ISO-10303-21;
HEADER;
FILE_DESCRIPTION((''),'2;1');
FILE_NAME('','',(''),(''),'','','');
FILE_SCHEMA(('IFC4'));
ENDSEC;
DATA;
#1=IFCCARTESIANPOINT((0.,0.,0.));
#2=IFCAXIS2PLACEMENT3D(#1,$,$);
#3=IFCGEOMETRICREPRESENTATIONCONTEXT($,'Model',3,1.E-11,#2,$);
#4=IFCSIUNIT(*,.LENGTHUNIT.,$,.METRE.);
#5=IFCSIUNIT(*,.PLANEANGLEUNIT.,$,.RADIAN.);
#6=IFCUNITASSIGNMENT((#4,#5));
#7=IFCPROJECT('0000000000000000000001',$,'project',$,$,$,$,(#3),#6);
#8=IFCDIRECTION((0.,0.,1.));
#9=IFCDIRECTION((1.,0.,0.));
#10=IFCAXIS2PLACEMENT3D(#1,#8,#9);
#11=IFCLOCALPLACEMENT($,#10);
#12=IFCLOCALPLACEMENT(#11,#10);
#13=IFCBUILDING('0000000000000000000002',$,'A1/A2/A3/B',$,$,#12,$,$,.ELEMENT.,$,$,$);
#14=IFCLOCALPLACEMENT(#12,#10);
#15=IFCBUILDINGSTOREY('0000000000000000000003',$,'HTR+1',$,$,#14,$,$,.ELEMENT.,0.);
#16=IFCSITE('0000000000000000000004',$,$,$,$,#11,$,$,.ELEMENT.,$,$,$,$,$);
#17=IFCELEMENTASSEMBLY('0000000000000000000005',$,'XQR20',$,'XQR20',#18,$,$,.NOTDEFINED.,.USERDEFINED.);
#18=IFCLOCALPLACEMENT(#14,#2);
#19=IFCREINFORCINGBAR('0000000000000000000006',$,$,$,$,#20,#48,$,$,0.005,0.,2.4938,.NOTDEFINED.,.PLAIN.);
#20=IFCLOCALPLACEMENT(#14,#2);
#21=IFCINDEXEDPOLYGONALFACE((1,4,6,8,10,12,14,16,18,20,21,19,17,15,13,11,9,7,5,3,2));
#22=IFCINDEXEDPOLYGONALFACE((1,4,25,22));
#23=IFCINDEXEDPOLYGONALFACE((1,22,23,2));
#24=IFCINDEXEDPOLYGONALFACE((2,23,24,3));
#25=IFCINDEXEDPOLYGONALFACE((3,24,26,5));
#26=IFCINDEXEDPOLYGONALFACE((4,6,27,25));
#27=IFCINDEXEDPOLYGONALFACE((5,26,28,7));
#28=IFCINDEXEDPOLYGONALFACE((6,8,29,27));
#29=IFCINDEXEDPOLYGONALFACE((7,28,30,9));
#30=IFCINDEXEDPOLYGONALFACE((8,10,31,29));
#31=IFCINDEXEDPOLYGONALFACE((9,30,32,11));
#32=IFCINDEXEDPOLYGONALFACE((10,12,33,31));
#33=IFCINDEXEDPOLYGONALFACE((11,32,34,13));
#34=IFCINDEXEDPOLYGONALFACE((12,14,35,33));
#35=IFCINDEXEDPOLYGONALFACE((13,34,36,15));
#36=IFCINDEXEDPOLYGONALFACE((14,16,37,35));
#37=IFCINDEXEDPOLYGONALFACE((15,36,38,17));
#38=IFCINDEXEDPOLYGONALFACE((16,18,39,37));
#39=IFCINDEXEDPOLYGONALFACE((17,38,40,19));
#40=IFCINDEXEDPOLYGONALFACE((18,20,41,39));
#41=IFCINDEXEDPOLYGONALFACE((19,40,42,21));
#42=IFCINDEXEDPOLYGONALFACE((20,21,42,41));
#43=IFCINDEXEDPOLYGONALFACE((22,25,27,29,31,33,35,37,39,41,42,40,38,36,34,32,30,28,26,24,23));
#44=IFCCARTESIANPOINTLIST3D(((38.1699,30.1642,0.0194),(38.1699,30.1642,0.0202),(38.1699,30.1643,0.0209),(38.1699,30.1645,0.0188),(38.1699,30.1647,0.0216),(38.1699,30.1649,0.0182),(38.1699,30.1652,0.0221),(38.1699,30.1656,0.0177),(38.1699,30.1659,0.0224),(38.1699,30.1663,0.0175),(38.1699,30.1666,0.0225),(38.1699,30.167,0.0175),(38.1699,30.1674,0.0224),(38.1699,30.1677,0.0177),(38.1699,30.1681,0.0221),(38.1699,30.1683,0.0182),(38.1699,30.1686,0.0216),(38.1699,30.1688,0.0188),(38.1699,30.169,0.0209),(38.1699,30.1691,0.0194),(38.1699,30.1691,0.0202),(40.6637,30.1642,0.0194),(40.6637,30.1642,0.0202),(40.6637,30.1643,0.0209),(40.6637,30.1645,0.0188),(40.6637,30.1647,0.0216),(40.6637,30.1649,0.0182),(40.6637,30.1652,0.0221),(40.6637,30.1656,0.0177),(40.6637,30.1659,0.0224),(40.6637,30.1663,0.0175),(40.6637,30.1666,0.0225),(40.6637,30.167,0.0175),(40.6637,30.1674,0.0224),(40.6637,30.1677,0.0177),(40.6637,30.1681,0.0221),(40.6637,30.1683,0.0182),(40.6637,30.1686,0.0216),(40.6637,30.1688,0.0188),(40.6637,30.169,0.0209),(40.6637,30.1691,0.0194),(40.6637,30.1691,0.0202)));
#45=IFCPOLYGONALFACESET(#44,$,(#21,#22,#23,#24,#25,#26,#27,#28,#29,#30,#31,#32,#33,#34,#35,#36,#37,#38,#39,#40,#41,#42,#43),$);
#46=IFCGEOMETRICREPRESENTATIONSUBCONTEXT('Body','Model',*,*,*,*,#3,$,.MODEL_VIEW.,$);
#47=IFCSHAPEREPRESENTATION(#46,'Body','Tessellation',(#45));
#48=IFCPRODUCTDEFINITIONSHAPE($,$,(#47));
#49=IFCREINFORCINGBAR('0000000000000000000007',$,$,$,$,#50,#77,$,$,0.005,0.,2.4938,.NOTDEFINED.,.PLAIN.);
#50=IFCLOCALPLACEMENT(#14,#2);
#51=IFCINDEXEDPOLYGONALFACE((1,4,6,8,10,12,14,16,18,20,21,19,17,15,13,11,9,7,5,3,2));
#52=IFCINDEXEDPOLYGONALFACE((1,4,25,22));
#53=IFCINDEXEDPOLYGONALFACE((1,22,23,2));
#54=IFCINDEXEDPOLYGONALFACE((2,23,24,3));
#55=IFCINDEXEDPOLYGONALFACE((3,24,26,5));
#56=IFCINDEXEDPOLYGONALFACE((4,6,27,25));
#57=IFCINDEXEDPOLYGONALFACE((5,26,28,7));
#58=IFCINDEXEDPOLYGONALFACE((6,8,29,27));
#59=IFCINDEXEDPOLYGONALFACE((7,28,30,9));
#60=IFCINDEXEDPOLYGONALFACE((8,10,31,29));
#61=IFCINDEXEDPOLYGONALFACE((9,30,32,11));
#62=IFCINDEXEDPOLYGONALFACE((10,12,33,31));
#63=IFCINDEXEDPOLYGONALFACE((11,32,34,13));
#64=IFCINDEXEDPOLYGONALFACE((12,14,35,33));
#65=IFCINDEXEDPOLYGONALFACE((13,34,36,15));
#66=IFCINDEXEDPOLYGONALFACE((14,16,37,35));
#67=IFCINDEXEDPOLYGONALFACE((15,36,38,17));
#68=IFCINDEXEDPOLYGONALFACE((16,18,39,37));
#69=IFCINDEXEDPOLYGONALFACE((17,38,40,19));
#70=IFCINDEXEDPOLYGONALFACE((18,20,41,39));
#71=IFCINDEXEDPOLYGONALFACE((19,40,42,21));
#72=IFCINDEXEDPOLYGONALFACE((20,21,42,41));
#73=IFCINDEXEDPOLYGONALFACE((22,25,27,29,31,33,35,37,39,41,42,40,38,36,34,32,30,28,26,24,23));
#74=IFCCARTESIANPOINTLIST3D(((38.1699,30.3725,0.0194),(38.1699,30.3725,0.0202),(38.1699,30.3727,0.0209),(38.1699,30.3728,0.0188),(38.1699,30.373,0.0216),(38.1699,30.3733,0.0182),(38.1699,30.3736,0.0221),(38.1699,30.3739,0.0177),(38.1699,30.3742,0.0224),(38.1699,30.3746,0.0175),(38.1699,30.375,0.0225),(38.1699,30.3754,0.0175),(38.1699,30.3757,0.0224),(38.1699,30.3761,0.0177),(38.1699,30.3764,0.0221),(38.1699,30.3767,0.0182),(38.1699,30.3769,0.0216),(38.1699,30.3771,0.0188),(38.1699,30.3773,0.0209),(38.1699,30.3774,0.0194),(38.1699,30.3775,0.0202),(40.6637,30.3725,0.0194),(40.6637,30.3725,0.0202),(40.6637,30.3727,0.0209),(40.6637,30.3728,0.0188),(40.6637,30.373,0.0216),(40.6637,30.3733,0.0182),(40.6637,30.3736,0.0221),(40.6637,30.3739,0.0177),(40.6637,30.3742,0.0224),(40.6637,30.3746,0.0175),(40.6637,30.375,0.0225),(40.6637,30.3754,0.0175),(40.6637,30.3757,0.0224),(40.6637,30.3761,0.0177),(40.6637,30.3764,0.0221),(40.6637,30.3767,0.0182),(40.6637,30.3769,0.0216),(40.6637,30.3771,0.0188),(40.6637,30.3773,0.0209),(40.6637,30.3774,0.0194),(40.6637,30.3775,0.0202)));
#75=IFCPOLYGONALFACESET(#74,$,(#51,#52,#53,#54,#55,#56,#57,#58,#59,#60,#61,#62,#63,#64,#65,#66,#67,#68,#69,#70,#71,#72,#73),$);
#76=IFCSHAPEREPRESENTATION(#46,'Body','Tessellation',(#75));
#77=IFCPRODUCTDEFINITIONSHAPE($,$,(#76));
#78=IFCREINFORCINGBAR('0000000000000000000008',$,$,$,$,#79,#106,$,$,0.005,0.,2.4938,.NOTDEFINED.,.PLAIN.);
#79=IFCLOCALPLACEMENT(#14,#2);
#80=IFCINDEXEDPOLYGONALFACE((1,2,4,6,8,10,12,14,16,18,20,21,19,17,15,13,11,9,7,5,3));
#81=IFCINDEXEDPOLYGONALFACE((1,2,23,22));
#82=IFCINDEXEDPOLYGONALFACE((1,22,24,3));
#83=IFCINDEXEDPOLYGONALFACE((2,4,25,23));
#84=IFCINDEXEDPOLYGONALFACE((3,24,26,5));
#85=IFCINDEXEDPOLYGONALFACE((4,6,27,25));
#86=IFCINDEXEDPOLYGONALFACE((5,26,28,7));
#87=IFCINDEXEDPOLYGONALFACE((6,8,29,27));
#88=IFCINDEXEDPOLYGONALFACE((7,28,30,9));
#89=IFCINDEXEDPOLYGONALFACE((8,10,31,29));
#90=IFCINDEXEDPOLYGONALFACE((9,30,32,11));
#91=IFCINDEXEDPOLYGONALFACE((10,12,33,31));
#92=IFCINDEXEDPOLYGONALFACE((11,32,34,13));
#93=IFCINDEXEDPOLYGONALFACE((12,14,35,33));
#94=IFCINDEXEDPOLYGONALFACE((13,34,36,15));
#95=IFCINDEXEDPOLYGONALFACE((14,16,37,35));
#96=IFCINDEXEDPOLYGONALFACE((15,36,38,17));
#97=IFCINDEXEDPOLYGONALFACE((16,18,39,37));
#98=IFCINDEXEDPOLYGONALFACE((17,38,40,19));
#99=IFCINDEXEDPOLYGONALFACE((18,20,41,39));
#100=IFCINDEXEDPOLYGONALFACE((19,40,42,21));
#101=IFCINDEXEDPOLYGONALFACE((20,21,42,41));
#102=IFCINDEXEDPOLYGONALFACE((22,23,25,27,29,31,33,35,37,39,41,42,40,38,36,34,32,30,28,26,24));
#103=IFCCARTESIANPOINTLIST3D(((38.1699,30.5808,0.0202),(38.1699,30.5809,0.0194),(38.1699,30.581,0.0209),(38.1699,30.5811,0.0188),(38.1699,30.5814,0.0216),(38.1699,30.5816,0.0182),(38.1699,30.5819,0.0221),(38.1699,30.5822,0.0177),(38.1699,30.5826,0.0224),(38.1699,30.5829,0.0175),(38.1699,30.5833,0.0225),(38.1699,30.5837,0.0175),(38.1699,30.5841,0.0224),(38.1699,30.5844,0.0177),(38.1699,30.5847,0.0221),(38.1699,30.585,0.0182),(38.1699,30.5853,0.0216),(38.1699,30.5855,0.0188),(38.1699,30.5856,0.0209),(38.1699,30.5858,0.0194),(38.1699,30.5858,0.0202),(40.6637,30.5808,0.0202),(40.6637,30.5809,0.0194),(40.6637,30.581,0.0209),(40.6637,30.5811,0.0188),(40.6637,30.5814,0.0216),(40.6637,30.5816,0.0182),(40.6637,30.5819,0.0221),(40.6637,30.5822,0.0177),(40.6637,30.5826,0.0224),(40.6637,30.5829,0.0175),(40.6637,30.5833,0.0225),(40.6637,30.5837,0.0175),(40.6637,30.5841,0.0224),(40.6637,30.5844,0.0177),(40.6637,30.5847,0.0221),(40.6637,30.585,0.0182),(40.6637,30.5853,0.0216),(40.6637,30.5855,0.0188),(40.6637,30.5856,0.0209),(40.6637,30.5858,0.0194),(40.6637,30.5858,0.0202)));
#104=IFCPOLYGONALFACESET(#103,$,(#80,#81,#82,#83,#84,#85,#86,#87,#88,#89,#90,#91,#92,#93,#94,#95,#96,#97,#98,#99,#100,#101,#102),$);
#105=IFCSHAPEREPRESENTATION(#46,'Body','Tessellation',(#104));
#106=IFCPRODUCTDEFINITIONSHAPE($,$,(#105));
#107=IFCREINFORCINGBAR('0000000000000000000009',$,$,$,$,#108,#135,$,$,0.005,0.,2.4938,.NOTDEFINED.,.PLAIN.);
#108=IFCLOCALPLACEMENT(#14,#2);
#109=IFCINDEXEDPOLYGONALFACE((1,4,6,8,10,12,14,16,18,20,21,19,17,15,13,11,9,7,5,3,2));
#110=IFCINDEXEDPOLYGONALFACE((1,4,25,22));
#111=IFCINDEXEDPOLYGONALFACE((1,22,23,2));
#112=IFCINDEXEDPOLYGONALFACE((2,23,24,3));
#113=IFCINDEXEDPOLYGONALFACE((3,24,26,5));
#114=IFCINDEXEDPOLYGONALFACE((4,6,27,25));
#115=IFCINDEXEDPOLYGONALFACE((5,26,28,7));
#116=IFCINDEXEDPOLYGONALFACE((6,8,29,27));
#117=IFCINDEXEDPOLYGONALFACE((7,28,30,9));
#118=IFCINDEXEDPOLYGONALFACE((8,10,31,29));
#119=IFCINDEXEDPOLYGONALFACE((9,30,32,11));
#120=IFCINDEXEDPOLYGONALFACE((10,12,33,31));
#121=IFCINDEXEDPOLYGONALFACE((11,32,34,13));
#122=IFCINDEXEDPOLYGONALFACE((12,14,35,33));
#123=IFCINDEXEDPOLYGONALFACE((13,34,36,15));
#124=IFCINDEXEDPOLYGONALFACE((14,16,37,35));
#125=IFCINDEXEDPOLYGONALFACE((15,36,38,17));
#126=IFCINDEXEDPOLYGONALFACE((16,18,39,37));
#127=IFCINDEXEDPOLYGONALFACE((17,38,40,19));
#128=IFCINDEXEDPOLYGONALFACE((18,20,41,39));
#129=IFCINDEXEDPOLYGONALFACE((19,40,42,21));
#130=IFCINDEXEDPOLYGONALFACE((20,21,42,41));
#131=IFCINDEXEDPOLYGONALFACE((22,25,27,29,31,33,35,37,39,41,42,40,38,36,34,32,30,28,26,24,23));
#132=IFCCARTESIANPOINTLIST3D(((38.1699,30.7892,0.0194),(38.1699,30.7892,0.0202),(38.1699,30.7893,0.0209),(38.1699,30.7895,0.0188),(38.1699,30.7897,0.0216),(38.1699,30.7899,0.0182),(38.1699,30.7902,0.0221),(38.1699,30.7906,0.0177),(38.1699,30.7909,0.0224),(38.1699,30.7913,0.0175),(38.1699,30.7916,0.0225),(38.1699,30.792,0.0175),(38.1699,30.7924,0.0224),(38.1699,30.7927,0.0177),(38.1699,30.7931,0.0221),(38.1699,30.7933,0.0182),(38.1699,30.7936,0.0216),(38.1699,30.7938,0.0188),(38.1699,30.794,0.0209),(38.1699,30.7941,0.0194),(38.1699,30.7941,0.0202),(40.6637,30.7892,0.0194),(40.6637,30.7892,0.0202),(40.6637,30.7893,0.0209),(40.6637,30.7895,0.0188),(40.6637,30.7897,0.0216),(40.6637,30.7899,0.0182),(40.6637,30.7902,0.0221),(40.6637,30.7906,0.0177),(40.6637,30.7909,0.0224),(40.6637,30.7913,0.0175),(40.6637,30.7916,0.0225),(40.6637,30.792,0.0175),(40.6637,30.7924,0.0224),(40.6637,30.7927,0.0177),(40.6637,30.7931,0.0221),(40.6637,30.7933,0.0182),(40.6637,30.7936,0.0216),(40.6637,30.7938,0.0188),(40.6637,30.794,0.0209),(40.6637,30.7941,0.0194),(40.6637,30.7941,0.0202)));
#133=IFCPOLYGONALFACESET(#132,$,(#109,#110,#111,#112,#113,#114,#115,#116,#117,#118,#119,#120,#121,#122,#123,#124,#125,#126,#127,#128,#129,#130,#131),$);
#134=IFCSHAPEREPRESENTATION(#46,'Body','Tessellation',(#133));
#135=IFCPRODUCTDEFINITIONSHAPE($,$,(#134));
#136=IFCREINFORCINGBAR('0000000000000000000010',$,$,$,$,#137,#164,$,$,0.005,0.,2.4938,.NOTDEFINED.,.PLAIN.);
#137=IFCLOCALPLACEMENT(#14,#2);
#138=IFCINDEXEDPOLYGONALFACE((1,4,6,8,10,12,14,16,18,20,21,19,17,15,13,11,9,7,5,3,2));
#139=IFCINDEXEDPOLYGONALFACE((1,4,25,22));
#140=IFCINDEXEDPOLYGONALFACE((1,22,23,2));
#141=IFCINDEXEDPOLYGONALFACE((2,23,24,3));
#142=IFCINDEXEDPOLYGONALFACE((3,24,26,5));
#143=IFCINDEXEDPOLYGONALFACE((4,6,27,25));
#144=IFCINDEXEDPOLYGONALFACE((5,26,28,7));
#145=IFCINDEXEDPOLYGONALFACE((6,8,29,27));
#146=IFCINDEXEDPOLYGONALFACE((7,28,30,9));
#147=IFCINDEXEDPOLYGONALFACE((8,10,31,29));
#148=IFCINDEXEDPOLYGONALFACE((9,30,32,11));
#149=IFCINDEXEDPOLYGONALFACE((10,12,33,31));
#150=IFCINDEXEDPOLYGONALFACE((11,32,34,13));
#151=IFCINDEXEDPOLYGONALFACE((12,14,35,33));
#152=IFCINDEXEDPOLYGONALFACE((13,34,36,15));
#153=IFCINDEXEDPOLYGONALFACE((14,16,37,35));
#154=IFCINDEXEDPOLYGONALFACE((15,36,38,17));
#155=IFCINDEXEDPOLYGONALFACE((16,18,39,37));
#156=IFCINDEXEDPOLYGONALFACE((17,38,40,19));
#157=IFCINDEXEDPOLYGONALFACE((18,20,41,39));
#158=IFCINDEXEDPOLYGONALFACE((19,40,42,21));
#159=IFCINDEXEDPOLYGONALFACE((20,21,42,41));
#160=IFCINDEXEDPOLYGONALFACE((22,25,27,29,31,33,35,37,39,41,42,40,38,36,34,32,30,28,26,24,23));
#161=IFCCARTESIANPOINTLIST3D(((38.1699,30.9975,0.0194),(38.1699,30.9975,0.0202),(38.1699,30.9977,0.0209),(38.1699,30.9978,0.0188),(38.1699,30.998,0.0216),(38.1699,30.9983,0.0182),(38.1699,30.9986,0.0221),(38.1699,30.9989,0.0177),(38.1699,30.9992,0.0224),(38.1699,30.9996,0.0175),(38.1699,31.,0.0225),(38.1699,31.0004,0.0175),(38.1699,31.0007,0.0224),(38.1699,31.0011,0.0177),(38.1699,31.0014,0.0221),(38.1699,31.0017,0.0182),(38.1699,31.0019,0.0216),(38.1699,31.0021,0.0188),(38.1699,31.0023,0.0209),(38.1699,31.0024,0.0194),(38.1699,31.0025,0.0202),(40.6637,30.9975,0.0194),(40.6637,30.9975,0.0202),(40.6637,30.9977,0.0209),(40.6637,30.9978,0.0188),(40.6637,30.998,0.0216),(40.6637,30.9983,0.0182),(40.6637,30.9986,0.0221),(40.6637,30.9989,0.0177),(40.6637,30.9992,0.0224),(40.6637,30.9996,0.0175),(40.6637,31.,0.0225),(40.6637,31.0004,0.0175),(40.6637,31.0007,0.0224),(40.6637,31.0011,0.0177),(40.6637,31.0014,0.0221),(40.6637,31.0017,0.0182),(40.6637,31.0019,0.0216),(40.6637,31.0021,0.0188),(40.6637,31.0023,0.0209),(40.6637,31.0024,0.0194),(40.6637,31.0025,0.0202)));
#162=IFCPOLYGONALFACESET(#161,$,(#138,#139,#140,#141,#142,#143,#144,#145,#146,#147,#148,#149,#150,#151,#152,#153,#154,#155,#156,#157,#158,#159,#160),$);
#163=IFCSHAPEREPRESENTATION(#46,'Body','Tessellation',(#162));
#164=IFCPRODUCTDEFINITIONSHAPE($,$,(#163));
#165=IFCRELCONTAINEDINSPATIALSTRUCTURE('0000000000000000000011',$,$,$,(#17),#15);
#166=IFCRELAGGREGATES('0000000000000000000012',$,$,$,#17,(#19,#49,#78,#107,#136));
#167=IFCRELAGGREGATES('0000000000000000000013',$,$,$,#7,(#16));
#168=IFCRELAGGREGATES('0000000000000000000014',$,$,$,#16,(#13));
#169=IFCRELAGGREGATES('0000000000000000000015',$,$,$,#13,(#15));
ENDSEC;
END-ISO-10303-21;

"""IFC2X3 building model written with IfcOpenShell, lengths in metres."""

from ifc_helpers import new_model, entity, si_unit, origin, origin_with_axes, place, context, subcontext, project, spatial, shape, element, aggregate, save


model = new_model("IFC2X3")

# Units and contexts
model_context = context("Model", 3, precision=1e-11, world=origin())
body_context = subcontext(model_context, "Body", "Model", "MODEL_VIEW")
ifc_project = project(units=[si_unit("LENGTHUNIT", "METRE"), si_unit("PLANEANGLEUNIT", "RADIAN")], contexts=[model_context])

# Site, building, storey
site_placement = place(None, origin_with_axes())
site = spatial("IfcSite", under=ifc_project, at=site_placement, CompositionType="ELEMENT")
building_placement = place(site_placement, origin_with_axes())
building = spatial("IfcBuilding", under=site, at=building_placement, Name="A1/A2/A3/B", CompositionType="ELEMENT")
storey_placement = place(building_placement, origin_with_axes())
storey = spatial("IfcBuildingStorey", under=building, at=storey_placement, Name="HTR+1", CompositionType="ELEMENT", Elevation=0.0)

# Element assembly, reinforcing bars
assembly_1_placement = place(storey_placement, origin_with_axes())
assembly_1 = element("IfcElementAssembly", 1, at=assembly_1_placement, inside=storey, Name="XQR20", ObjectType="XQR20", AssemblyPlace="NOTDEFINED", PredefinedType="USERDEFINED")
reinforcing_bar_1_placement = place(assembly_1_placement, origin_with_axes())
reinforcing_bar_1 = element("IfcReinforcingBar", 2, at=reinforcing_bar_1_placement, BarLength=2.4938, BarRole="NOTDEFINED", BarSurface="PLAIN", CrossSectionArea=0.0, NominalDiameter=0.005, shapes=[
    shape(body_context, "Body", "AdvancedSweptSolid", [entity("IfcSweptDiskSolid", entity("IfcPolyline", [entity("IfcCartesianPoint", [38.1699, 30.1666, 0.02]), entity("IfcCartesianPoint", [40.6637, 30.1666, 0.02])]), 0.0025, None, 0.0, 2.4938)]),
    shape(body_context, "Body", "AdvancedSweptSolid", [entity("IfcSweptDiskSolid", entity("IfcPolyline", [entity("IfcCartesianPoint", [38.1699, 30.1666, 0.02]), entity("IfcCartesianPoint", [40.6637, 30.1666, 0.02])]), 0.0025, None, 0.0, 2.4938)]),
])
reinforcing_bar_2_placement = place(assembly_1_placement, origin_with_axes())
reinforcing_bar_2 = element("IfcReinforcingBar", 3, at=reinforcing_bar_2_placement, BarLength=2.4938, BarRole="NOTDEFINED", BarSurface="PLAIN", CrossSectionArea=0.0, NominalDiameter=0.005, shapes=[
    shape(body_context, "Body", "AdvancedSweptSolid", [entity("IfcSweptDiskSolid", entity("IfcPolyline", [entity("IfcCartesianPoint", [38.1699, 30.375, 0.02]), entity("IfcCartesianPoint", [40.6637, 30.375, 0.02])]), 0.0025, None, 0.0, 2.4938)]),
    shape(body_context, "Body", "AdvancedSweptSolid", [entity("IfcSweptDiskSolid", entity("IfcPolyline", [entity("IfcCartesianPoint", [38.1699, 30.375, 0.02]), entity("IfcCartesianPoint", [40.6637, 30.375, 0.02])]), 0.0025, None, 0.0, 2.4938)]),
])
reinforcing_bar_3_placement = place(assembly_1_placement, origin_with_axes())
reinforcing_bar_3 = element("IfcReinforcingBar", 4, at=reinforcing_bar_3_placement, BarLength=2.4938, BarRole="NOTDEFINED", BarSurface="PLAIN", CrossSectionArea=0.0, NominalDiameter=0.005, shapes=[
    shape(body_context, "Body", "AdvancedSweptSolid", [entity("IfcSweptDiskSolid", entity("IfcPolyline", [entity("IfcCartesianPoint", [38.1699, 30.5833, 0.02]), entity("IfcCartesianPoint", [40.6637, 30.5833, 0.02])]), 0.0025, None, 0.0, 2.4938)]),
    shape(body_context, "Body", "AdvancedSweptSolid", [entity("IfcSweptDiskSolid", entity("IfcPolyline", [entity("IfcCartesianPoint", [38.1699, 30.5833, 0.02]), entity("IfcCartesianPoint", [40.6637, 30.5833, 0.02])]), 0.0025, None, 0.0, 2.4938)]),
])
reinforcing_bar_4_placement = place(assembly_1_placement, origin_with_axes())
reinforcing_bar_4 = element("IfcReinforcingBar", 5, at=reinforcing_bar_4_placement, BarLength=2.4938, BarRole="NOTDEFINED", BarSurface="PLAIN", CrossSectionArea=0.0, NominalDiameter=0.005, shapes=[
    shape(body_context, "Body", "AdvancedSweptSolid", [entity("IfcSweptDiskSolid", entity("IfcPolyline", [entity("IfcCartesianPoint", [38.1699, 30.7916, 0.02]), entity("IfcCartesianPoint", [40.6637, 30.7916, 0.02])]), 0.0025, None, 0.0, 2.4938)]),
    shape(body_context, "Body", "AdvancedSweptSolid", [entity("IfcSweptDiskSolid", entity("IfcPolyline", [entity("IfcCartesianPoint", [38.1699, 30.7916, 0.02]), entity("IfcCartesianPoint", [40.6637, 30.7916, 0.02])]), 0.0025, None, 0.0, 2.4938)]),
])
reinforcing_bar_5_placement = place(assembly_1_placement, origin_with_axes())
reinforcing_bar_5 = element("IfcReinforcingBar", 6, at=reinforcing_bar_5_placement, BarLength=2.4938, BarRole="NOTDEFINED", BarSurface="PLAIN", CrossSectionArea=0.0, NominalDiameter=0.005, shapes=[
    shape(body_context, "Body", "AdvancedSweptSolid", [entity("IfcSweptDiskSolid", entity("IfcPolyline", [entity("IfcCartesianPoint", [38.1699, 31.0, 0.02]), entity("IfcCartesianPoint", [40.6637, 31.0, 0.02])]), 0.0025, None, 0.0, 2.4938)]),
    shape(body_context, "Body", "AdvancedSweptSolid", [entity("IfcSweptDiskSolid", entity("IfcPolyline", [entity("IfcCartesianPoint", [38.1699, 31.0, 0.02]), entity("IfcCartesianPoint", [40.6637, 31.0, 0.02])]), 0.0025, None, 0.0, 2.4938)]),
])
aggregate(assembly_1, [reinforcing_bar_1, reinforcing_bar_2, reinforcing_bar_3, reinforcing_bar_4, reinforcing_bar_5])

save(model, "model.ifc")
